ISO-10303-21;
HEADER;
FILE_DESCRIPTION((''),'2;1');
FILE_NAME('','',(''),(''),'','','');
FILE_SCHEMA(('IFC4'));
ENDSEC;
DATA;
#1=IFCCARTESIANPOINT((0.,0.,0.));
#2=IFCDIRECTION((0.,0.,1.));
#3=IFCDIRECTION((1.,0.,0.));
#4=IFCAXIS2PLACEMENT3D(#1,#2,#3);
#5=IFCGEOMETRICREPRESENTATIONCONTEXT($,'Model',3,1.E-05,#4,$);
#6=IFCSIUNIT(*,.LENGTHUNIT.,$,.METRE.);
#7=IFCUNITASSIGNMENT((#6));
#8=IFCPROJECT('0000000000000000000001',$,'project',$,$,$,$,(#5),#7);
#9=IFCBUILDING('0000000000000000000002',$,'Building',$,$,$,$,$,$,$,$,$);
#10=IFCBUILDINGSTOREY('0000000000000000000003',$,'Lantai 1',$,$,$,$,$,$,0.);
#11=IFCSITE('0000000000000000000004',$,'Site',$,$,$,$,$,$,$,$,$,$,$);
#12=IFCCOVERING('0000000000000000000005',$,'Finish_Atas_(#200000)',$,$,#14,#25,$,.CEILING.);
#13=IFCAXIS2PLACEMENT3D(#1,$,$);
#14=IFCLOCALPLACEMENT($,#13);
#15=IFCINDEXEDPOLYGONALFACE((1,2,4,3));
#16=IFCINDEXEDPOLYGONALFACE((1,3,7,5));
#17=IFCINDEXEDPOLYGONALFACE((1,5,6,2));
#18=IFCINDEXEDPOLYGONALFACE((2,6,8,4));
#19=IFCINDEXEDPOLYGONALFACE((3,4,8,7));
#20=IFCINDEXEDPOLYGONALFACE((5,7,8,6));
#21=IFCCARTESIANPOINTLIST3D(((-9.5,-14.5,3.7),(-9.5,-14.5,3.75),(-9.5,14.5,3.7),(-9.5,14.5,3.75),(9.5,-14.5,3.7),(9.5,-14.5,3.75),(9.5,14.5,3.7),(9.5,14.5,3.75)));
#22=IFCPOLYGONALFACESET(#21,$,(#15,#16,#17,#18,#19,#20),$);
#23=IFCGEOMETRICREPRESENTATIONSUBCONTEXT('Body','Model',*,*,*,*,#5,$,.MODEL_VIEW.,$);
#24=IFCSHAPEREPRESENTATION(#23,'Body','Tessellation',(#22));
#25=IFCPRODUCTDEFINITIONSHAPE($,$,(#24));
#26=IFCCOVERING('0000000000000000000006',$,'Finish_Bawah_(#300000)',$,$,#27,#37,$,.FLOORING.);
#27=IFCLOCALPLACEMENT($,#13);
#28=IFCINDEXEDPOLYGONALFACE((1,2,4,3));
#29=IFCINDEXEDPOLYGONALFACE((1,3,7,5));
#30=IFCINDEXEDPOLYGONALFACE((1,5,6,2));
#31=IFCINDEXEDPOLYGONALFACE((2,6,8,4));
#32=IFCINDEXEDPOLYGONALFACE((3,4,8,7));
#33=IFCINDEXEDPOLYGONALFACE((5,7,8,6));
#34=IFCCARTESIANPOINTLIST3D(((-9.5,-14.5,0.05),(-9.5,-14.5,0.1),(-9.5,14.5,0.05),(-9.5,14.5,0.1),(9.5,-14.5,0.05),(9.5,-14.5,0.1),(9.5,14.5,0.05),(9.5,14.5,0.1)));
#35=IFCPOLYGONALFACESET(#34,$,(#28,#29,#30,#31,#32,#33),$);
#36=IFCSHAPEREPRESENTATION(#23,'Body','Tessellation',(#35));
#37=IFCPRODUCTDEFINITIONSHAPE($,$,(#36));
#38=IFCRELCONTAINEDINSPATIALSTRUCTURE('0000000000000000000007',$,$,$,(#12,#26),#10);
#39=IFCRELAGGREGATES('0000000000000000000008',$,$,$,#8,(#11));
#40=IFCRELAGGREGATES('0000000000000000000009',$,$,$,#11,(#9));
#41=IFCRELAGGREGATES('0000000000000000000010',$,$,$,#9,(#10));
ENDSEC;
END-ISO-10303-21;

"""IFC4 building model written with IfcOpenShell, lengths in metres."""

from ifc_helpers import new_model, si_unit, frame, origin_with_axes, place, context, subcontext, project, spatial, polyline, outline, extrude, element, save


model = new_model("IFC4")

# Units and contexts
model_context = context("Model", 3, precision=1e-05, world=origin_with_axes())
body_context = subcontext(model_context, "Body", "Model", "MODEL_VIEW")
ifc_project = project(units=[si_unit("LENGTHUNIT", "METRE")], contexts=[model_context])

# Site, building, storey
site = spatial("IfcSite", under=ifc_project, Name="Site")
building = spatial("IfcBuilding", under=site, Name="Building")
storey = spatial("IfcBuildingStorey", under=building, Name="Lantai 1", Elevation=0.0)

# Coverings
covering_1_placement = place(None, origin_with_axes())
element("IfcCovering", 1, at=covering_1_placement, inside=storey, Name="Finish_Atas_(#200000)", PredefinedType="CEILING", context=body_context, shape_type="SweptSolid", body=[
    extrude(outline(polyline([(-9.5, -14.5), (9.5, -14.5), (9.5, 14.5), (-9.5, 14.5), (-9.5, -14.5)])), frame((0.0, 0.0, 3.7), z_axis=(0.0, 0.0, 1.0), x_axis=(1.0, 0.0, 0.0)), (0.0, 0.0, 1.0), 0.05),
])
covering_2_placement = place(None, origin_with_axes())
element("IfcCovering", 2, at=covering_2_placement, inside=storey, Name="Finish_Bawah_(#300000)", PredefinedType="FLOORING", context=body_context, shape_type="SweptSolid", body=[
    extrude(outline(polyline([(-9.5, -14.5), (9.5, -14.5), (9.5, 14.5), (-9.5, 14.5), (-9.5, -14.5)])), frame((0.0, 0.0, 0.05), z_axis=(0.0, 0.0, 1.0), x_axis=(1.0, 0.0, 0.0)), (0.0, 0.0, 1.0), 0.05),
])

save(model, "model.ifc")
